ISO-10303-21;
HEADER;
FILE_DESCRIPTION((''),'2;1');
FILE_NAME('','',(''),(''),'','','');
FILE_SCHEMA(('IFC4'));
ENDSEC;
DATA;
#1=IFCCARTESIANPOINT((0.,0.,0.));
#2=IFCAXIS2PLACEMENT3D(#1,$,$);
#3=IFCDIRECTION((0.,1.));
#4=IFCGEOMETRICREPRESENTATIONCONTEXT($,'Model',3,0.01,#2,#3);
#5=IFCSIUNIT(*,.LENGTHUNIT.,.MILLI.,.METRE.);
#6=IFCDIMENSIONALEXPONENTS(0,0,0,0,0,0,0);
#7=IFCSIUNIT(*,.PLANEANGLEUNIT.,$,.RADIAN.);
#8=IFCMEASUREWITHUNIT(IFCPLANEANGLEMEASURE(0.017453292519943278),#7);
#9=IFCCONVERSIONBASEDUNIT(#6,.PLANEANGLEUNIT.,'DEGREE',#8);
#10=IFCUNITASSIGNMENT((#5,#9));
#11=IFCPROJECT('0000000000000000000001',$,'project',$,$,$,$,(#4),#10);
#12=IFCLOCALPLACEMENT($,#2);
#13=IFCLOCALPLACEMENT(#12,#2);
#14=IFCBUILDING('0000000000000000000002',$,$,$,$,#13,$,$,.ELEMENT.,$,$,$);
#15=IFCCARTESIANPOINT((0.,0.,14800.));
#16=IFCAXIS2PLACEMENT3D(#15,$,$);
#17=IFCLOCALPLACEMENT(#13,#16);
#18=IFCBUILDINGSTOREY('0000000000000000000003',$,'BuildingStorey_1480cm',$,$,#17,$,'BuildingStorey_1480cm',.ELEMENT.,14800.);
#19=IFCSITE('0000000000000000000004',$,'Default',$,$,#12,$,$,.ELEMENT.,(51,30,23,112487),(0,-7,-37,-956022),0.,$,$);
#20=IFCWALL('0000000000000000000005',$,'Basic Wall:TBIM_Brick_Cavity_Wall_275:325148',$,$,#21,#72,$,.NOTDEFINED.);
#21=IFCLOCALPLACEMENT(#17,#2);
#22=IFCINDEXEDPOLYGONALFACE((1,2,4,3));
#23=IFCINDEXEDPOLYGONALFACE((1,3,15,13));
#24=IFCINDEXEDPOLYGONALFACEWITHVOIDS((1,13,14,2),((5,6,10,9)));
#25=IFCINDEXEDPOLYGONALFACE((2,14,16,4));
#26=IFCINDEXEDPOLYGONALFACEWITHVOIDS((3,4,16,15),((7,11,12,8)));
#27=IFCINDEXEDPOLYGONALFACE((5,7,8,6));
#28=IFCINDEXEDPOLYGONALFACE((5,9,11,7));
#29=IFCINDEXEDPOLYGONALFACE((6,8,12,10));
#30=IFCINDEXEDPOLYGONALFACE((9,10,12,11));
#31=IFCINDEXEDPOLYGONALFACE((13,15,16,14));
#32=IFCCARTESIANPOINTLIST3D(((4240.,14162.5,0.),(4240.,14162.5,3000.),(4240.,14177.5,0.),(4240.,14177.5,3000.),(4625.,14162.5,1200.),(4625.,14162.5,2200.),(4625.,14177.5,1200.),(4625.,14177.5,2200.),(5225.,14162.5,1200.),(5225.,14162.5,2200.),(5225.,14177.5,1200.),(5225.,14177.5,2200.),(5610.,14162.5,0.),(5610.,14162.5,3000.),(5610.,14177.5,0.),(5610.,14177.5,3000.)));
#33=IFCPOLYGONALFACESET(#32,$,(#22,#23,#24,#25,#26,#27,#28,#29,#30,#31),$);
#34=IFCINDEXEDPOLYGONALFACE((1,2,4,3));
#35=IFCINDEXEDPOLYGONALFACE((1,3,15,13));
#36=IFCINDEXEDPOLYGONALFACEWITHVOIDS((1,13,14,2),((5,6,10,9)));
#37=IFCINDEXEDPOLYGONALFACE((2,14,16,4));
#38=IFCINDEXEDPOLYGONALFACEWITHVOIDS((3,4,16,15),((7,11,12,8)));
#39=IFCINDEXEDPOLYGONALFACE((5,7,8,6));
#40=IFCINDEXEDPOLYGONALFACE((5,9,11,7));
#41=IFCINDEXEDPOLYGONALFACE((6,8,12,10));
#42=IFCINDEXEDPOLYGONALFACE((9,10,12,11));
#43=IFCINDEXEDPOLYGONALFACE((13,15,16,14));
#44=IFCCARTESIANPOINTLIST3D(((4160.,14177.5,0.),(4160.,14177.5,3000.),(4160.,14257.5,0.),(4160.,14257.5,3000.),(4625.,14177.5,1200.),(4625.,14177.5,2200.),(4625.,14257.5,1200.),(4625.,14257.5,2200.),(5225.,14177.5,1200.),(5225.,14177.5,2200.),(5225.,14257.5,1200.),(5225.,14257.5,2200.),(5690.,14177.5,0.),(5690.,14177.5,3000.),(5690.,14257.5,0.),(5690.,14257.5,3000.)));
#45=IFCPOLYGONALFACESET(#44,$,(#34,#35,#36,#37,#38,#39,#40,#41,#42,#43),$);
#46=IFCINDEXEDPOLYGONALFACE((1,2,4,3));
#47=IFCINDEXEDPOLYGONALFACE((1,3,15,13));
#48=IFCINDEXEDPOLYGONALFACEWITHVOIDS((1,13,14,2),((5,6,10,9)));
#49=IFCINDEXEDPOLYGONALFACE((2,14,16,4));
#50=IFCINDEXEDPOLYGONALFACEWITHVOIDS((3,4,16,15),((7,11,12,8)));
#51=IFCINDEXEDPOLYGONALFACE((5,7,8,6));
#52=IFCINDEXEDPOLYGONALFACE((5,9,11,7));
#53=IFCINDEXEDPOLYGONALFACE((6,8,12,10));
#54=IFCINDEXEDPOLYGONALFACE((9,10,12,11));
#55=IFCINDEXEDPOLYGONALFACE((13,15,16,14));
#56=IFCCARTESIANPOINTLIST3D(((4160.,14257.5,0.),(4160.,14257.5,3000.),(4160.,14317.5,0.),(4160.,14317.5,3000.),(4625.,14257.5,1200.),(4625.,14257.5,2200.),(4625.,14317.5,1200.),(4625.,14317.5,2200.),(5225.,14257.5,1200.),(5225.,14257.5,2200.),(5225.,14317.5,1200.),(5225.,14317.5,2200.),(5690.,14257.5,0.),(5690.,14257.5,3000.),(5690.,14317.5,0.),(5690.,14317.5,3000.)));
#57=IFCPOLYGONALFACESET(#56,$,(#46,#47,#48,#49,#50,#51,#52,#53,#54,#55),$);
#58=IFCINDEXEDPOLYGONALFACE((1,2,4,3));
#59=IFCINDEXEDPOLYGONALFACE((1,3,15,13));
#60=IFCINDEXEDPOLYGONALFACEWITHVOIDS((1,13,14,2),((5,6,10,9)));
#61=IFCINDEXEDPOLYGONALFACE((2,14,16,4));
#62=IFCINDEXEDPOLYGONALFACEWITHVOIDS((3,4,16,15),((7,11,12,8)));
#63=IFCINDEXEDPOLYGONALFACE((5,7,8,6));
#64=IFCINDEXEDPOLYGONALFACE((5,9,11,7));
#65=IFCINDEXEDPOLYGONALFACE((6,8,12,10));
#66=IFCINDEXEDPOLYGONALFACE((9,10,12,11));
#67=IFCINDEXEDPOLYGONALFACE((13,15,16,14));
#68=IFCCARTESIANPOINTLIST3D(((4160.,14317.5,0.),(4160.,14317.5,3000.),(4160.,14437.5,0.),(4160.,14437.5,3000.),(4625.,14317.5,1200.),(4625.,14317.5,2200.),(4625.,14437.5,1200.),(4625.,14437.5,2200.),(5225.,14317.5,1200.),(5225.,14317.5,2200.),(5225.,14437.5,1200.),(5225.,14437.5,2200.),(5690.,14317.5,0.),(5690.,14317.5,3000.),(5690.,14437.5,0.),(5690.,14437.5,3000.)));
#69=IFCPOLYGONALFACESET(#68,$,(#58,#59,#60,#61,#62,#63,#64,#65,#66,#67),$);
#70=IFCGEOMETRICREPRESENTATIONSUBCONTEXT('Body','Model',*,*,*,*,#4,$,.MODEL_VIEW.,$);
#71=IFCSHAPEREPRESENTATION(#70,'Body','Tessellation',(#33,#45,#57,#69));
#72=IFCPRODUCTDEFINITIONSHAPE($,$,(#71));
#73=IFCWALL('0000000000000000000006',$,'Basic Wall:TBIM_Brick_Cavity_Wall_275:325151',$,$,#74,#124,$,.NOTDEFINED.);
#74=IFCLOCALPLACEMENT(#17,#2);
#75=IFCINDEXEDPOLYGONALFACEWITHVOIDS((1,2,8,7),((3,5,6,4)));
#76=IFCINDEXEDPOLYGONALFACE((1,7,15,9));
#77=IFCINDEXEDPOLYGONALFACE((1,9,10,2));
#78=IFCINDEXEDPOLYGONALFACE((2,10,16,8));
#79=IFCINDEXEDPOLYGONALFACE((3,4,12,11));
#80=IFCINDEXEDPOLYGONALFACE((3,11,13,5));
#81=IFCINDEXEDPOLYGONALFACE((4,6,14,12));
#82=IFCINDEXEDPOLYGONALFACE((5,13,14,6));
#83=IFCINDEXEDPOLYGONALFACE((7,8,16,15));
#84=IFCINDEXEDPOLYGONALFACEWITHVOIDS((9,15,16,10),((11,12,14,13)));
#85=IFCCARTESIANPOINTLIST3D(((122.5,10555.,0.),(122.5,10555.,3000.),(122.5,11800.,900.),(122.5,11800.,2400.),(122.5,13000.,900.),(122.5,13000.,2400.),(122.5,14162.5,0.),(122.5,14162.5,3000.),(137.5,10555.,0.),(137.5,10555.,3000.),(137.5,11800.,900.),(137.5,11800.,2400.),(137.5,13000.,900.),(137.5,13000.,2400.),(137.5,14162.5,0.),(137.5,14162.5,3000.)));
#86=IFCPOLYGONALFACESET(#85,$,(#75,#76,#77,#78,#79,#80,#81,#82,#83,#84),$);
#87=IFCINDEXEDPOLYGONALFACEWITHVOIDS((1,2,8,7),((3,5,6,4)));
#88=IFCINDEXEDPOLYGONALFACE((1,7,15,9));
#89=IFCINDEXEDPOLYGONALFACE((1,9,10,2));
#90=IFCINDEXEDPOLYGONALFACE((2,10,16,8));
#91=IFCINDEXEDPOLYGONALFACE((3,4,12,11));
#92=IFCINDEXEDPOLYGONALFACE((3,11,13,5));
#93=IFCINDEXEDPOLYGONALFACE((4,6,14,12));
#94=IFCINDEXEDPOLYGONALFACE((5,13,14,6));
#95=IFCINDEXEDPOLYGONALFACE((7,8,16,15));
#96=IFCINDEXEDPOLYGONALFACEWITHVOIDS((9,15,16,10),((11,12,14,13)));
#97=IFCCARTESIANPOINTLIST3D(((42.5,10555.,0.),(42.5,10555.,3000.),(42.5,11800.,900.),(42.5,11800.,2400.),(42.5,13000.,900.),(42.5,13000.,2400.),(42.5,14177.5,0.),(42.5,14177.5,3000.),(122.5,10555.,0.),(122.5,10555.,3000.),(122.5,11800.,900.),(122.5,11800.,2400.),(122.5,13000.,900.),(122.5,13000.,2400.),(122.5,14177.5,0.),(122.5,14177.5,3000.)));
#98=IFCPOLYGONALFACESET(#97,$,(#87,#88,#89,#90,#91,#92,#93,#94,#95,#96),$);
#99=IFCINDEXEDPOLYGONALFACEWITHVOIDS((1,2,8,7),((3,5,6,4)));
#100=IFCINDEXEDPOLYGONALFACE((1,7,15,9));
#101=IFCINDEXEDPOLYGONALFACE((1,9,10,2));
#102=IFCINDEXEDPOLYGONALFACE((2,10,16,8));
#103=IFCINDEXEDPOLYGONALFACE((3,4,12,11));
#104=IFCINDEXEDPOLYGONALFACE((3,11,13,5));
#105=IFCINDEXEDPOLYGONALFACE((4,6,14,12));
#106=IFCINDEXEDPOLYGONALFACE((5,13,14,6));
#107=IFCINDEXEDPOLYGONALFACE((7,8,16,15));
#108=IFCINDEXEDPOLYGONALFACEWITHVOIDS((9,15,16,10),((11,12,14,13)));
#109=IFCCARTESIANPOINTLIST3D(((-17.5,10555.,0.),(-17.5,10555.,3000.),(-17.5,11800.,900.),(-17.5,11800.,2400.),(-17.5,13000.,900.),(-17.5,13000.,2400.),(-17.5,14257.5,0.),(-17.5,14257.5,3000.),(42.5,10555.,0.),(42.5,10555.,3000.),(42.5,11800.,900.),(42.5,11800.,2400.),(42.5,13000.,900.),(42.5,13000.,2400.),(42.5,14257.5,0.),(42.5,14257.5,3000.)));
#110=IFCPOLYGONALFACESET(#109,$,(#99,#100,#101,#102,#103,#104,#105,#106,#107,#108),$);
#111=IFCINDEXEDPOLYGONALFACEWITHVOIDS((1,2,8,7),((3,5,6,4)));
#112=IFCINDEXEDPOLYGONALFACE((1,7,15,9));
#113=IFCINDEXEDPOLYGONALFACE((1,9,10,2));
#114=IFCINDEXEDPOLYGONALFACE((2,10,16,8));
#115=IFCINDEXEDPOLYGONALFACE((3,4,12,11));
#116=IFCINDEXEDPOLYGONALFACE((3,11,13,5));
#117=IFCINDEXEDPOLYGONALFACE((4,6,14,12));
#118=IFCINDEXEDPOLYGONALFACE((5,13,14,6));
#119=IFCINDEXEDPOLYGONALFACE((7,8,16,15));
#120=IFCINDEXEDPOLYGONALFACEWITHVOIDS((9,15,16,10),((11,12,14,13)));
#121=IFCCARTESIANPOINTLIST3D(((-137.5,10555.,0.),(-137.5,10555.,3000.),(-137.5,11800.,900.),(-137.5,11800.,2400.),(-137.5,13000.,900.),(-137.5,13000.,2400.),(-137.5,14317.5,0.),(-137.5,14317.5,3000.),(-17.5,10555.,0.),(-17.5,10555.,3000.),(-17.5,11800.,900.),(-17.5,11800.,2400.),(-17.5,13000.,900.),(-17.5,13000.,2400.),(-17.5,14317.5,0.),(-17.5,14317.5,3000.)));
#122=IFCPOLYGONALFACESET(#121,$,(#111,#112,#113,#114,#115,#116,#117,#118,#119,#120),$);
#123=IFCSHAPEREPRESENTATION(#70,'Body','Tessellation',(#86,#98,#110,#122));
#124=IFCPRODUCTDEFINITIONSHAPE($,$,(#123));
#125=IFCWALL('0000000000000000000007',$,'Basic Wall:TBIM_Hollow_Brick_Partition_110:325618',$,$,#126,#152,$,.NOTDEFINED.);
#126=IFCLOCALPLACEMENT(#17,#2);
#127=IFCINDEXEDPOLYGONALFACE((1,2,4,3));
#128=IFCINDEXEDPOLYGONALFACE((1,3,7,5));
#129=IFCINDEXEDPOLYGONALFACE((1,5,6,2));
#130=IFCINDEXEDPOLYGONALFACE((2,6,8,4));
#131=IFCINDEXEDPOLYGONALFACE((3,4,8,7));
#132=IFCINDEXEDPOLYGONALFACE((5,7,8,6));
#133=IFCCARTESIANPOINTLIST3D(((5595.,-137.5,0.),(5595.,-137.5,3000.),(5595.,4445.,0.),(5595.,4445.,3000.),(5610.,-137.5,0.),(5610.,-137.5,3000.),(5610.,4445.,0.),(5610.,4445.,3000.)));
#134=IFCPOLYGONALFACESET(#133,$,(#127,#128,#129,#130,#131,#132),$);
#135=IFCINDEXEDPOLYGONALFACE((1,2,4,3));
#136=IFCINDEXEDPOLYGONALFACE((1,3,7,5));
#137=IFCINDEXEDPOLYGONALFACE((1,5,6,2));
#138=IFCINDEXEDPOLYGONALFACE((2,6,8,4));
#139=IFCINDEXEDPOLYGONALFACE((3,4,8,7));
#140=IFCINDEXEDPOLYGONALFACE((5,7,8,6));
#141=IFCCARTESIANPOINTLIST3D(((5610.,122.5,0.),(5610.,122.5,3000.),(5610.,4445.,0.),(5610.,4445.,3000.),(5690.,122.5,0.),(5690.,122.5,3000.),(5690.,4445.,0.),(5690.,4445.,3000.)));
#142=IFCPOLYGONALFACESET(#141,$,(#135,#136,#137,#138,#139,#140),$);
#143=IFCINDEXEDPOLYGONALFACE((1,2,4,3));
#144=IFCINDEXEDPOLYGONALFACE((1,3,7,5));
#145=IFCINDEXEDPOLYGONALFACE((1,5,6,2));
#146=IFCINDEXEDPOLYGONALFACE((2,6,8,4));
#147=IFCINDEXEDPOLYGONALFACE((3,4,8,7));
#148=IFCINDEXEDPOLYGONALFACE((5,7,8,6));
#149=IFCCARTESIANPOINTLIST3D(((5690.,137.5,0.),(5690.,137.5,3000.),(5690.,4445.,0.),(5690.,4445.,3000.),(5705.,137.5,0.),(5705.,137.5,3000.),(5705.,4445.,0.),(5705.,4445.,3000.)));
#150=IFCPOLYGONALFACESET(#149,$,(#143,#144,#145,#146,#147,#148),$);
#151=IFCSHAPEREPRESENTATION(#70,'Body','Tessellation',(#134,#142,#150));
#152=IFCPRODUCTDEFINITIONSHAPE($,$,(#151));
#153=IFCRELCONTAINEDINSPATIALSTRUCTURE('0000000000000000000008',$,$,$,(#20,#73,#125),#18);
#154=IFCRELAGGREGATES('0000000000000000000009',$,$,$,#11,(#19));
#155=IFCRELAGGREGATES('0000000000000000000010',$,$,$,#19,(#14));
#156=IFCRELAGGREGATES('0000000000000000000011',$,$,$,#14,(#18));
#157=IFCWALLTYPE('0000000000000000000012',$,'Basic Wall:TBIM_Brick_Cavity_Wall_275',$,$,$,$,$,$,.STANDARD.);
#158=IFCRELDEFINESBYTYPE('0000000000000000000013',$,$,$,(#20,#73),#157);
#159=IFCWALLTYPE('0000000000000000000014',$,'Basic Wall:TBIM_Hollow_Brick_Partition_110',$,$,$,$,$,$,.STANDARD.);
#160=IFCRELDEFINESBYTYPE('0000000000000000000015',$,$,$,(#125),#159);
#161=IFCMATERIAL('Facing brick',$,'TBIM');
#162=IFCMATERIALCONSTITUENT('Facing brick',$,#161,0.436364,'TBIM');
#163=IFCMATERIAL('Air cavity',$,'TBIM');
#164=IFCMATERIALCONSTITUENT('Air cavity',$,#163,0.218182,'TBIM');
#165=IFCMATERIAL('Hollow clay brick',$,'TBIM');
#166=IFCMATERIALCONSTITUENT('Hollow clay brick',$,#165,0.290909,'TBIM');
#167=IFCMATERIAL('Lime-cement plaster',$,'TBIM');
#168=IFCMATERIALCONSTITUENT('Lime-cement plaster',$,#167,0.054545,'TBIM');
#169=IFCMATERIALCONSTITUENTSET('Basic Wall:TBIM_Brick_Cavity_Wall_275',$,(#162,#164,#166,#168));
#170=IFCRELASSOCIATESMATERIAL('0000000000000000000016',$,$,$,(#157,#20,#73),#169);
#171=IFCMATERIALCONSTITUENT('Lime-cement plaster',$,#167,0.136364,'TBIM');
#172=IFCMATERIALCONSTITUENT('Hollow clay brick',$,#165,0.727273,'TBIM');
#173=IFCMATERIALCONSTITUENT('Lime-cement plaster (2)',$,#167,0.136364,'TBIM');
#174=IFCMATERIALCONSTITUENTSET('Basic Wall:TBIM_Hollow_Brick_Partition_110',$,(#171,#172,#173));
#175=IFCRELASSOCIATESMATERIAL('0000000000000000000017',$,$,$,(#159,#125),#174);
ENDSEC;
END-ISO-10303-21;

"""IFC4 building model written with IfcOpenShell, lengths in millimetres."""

from ifc_helpers import new_model, entity, si_unit, converted_unit, direction, frame, origin, place, context, subcontext, project, spatial, indexed_curve, outline, extrude, material, constituent, constituent_set, type_object, element, save


model = new_model("IFC4")

# Units and contexts
model_context = context("Model", 3, precision=0.01, world=origin(), true_north=direction((0.0, 1.0)))
body_context = subcontext(model_context, "Body", "Model", "MODEL_VIEW")
ifc_project = project(units=[si_unit("LENGTHUNIT", "METRE", prefix="MILLI"), converted_unit("PLANEANGLEUNIT", "DEGREE", entity("IfcPlaneAngleMeasure", 0.017453292519943278), si_unit("PLANEANGLEUNIT", "RADIAN"), dimensions=[0, 0, 0, 0, 0, 0, 0])], contexts=[model_context])

# Site, building, storey
site_placement = place(None, origin())
site = spatial("IfcSite", under=ifc_project, at=site_placement, Name="Default", CompositionType="ELEMENT", RefLatitude=(51, 30, 23, 112487), RefLongitude=(0, -7, -37, -956022), RefElevation=0.0)
building_placement = place(site_placement, origin())
building = spatial("IfcBuilding", under=site, at=building_placement, CompositionType="ELEMENT")
storey_placement = place(building_placement, frame((0.0, 0.0, 14800.0)))
storey = spatial("IfcBuildingStorey", under=building, at=storey_placement, Name="BuildingStorey_1480cm", LongName="BuildingStorey_1480cm", CompositionType="ELEMENT", Elevation=14800.0)

# Shared definitions
ifc_material_1 = material(Name="Lime-cement plaster", Category="TBIM")

# Walls, openings
ifc_material_2 = material(Name="Facing brick", Category="TBIM")
ifc_constituent_1 = constituent(ifc_material_2, Name="Facing brick", Category="TBIM", fraction=0.436364)
ifc_material_3 = material(Name="Air cavity", Category="TBIM")
ifc_constituent_2 = constituent(ifc_material_3, Name="Air cavity", Category="TBIM", fraction=0.218182)
ifc_material_4 = material(Name="Hollow clay brick", Category="TBIM")
ifc_constituent_3 = constituent(ifc_material_4, Name="Hollow clay brick", Category="TBIM", fraction=0.290909)
ifc_constituent_4 = constituent(ifc_material_1, Name="Lime-cement plaster", Category="TBIM", fraction=0.054545)
ifc_constituent_set_1 = constituent_set(constituents=[ifc_constituent_1, ifc_constituent_2, ifc_constituent_3, ifc_constituent_4], Name="Basic Wall:TBIM_Brick_Cavity_Wall_275")
wall_type_1 = type_object("IfcWallType", Name="Basic Wall:TBIM_Brick_Cavity_Wall_275", PredefinedType="STANDARD", material=ifc_constituent_set_1)
wall_1_placement = place(storey_placement, frame((5705.0, 14300.0, 0.0), z_axis=(0.0, 0.0, 1.0), x_axis=(-1.0, 0.0, 0.0)))
wall_1 = element("IfcWall", 1, at=wall_1_placement, inside=storey, type_object=wall_type_1, material=ifc_constituent_set_1, Name="Basic Wall:TBIM_Brick_Cavity_Wall_275:325148", PredefinedType="NOTDEFINED", context=body_context, shape_type="SweptSolid", body=[
    extrude(outline(indexed_curve([(-685.0, -1500.0), (-670.0, -1500.0), (670.0, -1500.0), (685.0, -1500.0), (685.0, 1500.0), (670.0, 1500.0), (-670.0, 1500.0), (-685.0, 1500.0), (-685.0, -1500.0)], self_intersect=False), holes=[indexed_curve([(-300.0, 700.0), (300.0, 700.0), (300.0, -300.0), (-300.0, -300.0), (-300.0, 700.0)], self_intersect=False)]), frame((780.0, 137.5, 1500.0), z_axis=(0.0, -1.0, 0.0), x_axis=(1.0, 0.0, 0.0)), (0.0, 0.0, 1.0), 15.0),
    extrude(outline(indexed_curve([(-1500.0, -765.0), (1500.0, -765.0), (1500.0, 765.0), (-1500.0, 765.0), (-1500.0, -765.0)], self_intersect=False), holes=[indexed_curve([(700.0, 300.0), (700.0, -300.0), (-300.0, -300.0), (-300.0, 300.0), (700.0, 300.0)], self_intersect=False)]), frame((780.0, 122.5, 1500.0), z_axis=(0.0, -1.0, 0.0), x_axis=(0.0, 0.0, 1.0)), (0.0, 0.0, 1.0), 80.0),
    extrude(outline(indexed_curve([(-1500.0, -765.0), (1500.0, -765.0), (1500.0, 765.0), (-1500.0, 765.0), (-1500.0, -765.0)], self_intersect=False), holes=[indexed_curve([(700.0, 300.0), (700.0, -300.0), (-300.0, -300.0), (-300.0, 300.0), (700.0, 300.0)], self_intersect=False)]), frame((780.0, 42.5, 1500.0), z_axis=(0.0, -1.0, 0.0), x_axis=(0.0, 0.0, 1.0)), (0.0, 0.0, 1.0), 60.0),
    extrude(outline(indexed_curve([(-1500.0, -765.0), (1500.0, -765.0), (1500.0, 765.0), (-1500.0, 765.0), (-1500.0, -765.0)], self_intersect=False), holes=[indexed_curve([(700.0, 300.0), (700.0, -300.0), (-300.0, -300.0), (-300.0, 300.0), (700.0, 300.0)], self_intersect=False)]), frame((780.0, -17.5, 1500.0), z_axis=(0.0, -1.0, 0.0), x_axis=(0.0, 0.0, 1.0)), (0.0, 0.0, 1.0), 120.0),
])
opening_1_placement = place(wall_1_placement, frame((480.0, -137.5, 1200.0)))
element("IfcOpeningElement", 2, at=opening_1_placement, cuts=wall_1, PredefinedType="OPENING", context=body_context, shape_type="SweptSolid", body=[
    extrude(outline(indexed_curve([(1000.0, 0.0), (1000.0, 600.0), (0.0, 600.0), (0.0, 0.0), (1000.0, 0.0)], self_intersect=False)), frame((0.0, 0.0, 0.0), z_axis=(0.0, 1.0, 0.0), x_axis=(0.0, 0.0, 1.0)), (0.0, 0.0, 1.0), 275.0),
])
wall_2_placement = place(storey_placement, frame((0.0, 10555.0, 0.0), z_axis=(0.0, 0.0, 1.0), x_axis=(0.0, 1.0, 0.0)))
wall_2 = element("IfcWall", 3, at=wall_2_placement, inside=storey, type_object=wall_type_1, material=ifc_constituent_set_1, Name="Basic Wall:TBIM_Brick_Cavity_Wall_275:325151", PredefinedType="NOTDEFINED", context=body_context, shape_type="SweptSolid", body=[
    extrude(outline(indexed_curve([(-1500.0, -1803.7), (1500.0, -1803.8), (1500.0, 1803.7), (-1500.0, 1803.7), (-1500.0, -1803.7)], self_intersect=False), holes=[indexed_curve([(900.0, 558.8), (900.0, -641.2), (-600.0, -641.2), (-600.0, 558.8), (900.0, 558.8)], self_intersect=False)]), frame((1803.7, -122.5, 1500.0), z_axis=(0.0, -1.0, 0.0), x_axis=(0.0, 0.0, 1.0)), (0.0, 0.0, 1.0), 15.0),
    extrude(outline(indexed_curve([(-1500.0, -1811.2), (1500.0, -1811.2), (1500.0, 1811.2), (-1500.0, 1811.2), (-1500.0, -1811.2)], self_intersect=False), holes=[indexed_curve([(900.0, 566.3), (900.0, -633.7), (-600.0, -633.7), (-600.0, 566.3), (900.0, 566.3)], self_intersect=False)]), frame((1811.2, -42.5, 1500.0), z_axis=(0.0, -1.0, 0.0), x_axis=(0.0, 0.0, 1.0)), (0.0, 0.0, 1.0), 80.0),
    extrude(outline(indexed_curve([(-1500.0, -1851.2), (1500.0, -1851.2), (1500.0, 1851.2), (-1500.0, 1851.2), (-1500.0, -1851.2)], self_intersect=False), holes=[indexed_curve([(900.0, 606.3), (900.0, -593.7), (-600.0, -593.7), (-600.0, 606.3), (900.0, 606.3)], self_intersect=False)]), frame((1851.2, 17.5, 1500.0), z_axis=(0.0, -1.0, 0.0), x_axis=(0.0, 0.0, 1.0)), (0.0, 0.0, 1.0), 60.0),
    extrude(outline(indexed_curve([(-1881.2, -1500.0), (1881.2, -1500.0), (1881.2, 1500.0), (-1881.2, 1500.0), (-1881.2, -1500.0)], self_intersect=False), holes=[indexed_curve([(-636.3, 900.0), (563.7, 900.0), (563.7, -600.0), (-636.3, -600.0), (-636.3, 900.0)], self_intersect=False)]), frame((1881.2, 137.5, 1500.0), z_axis=(0.0, -1.0, 0.0), x_axis=(1.0, 0.0, 0.0)), (0.0, 0.0, 1.0), 120.0),
])
opening_2_placement = place(wall_2_placement, frame((1245.0, -137.5, 900.0)))
element("IfcOpeningElement", 4, at=opening_2_placement, cuts=wall_2, PredefinedType="OPENING", context=body_context, shape_type="SweptSolid", body=[
    extrude(outline(indexed_curve([(1500.0, 0.0), (1500.0, 1200.0), (0.0, 1200.0), (0.0, 0.0), (1500.0, 0.0)], self_intersect=False)), frame((0.0, 0.0, 0.0), z_axis=(0.0, 1.0, 0.0), x_axis=(0.0, 0.0, 1.0)), (0.0, 0.0, 1.0), 275.0),
])

# Wall
ifc_constituent_5 = constituent(ifc_material_1, Name="Lime-cement plaster", Category="TBIM", fraction=0.136364)
ifc_constituent_6 = constituent(ifc_material_4, Name="Hollow clay brick", Category="TBIM", fraction=0.727273)
ifc_constituent_7 = constituent(ifc_material_1, Name="Lime-cement plaster (2)", Category="TBIM", fraction=0.136364)
ifc_constituent_set_2 = constituent_set(constituents=[ifc_constituent_5, ifc_constituent_6, ifc_constituent_7], Name="Basic Wall:TBIM_Hollow_Brick_Partition_110")
wall_type_2 = type_object("IfcWallType", Name="Basic Wall:TBIM_Hollow_Brick_Partition_110", PredefinedType="STANDARD", material=ifc_constituent_set_2)
wall_3_placement = place(storey_placement, frame((5650.0, 137.5, 0.0), z_axis=(0.0, 0.0, 1.0), x_axis=(0.0, 1.0, 0.0)))
element("IfcWall", 5, at=wall_3_placement, inside=storey, type_object=wall_type_2, material=ifc_constituent_set_2, Name="Basic Wall:TBIM_Hollow_Brick_Partition_110:325618", PredefinedType="NOTDEFINED", context=body_context, shape_type="SweptSolid", body=[
    extrude(outline(indexed_curve([(-7.5, -2291.2), (7.5, -2291.2), (7.5, 2291.2), (-7.5, 2291.2), (-7.5, -2291.2)], self_intersect=False)), frame((2016.2, 47.5, 0.0), z_axis=(0.0, 0.0, 1.0), x_axis=(0.0, -1.0, 0.0)), (0.0, 0.0, 1.0), 3000.0),
    extrude(outline(indexed_curve([(-2161.2, -40.0), (2161.2, -40.0), (2161.2, 40.0), (-2161.3, 40.0), (-2161.2, -40.0)], self_intersect=False)), frame((2146.2, 0.0, 0.0)), (0.0, 0.0, 1.0), 3000.0),
    extrude(outline(indexed_curve([(-7.5, -2153.8), (7.5, -2153.8), (7.5, 2153.8), (-7.5, 2153.8), (-7.5, -2153.8)], self_intersect=False)), frame((2153.8, -47.5, 0.0), z_axis=(0.0, 0.0, 1.0), x_axis=(0.0, 1.0, 0.0)), (0.0, 0.0, 1.0), 3000.0),
])

save(model, "model.ifc")
